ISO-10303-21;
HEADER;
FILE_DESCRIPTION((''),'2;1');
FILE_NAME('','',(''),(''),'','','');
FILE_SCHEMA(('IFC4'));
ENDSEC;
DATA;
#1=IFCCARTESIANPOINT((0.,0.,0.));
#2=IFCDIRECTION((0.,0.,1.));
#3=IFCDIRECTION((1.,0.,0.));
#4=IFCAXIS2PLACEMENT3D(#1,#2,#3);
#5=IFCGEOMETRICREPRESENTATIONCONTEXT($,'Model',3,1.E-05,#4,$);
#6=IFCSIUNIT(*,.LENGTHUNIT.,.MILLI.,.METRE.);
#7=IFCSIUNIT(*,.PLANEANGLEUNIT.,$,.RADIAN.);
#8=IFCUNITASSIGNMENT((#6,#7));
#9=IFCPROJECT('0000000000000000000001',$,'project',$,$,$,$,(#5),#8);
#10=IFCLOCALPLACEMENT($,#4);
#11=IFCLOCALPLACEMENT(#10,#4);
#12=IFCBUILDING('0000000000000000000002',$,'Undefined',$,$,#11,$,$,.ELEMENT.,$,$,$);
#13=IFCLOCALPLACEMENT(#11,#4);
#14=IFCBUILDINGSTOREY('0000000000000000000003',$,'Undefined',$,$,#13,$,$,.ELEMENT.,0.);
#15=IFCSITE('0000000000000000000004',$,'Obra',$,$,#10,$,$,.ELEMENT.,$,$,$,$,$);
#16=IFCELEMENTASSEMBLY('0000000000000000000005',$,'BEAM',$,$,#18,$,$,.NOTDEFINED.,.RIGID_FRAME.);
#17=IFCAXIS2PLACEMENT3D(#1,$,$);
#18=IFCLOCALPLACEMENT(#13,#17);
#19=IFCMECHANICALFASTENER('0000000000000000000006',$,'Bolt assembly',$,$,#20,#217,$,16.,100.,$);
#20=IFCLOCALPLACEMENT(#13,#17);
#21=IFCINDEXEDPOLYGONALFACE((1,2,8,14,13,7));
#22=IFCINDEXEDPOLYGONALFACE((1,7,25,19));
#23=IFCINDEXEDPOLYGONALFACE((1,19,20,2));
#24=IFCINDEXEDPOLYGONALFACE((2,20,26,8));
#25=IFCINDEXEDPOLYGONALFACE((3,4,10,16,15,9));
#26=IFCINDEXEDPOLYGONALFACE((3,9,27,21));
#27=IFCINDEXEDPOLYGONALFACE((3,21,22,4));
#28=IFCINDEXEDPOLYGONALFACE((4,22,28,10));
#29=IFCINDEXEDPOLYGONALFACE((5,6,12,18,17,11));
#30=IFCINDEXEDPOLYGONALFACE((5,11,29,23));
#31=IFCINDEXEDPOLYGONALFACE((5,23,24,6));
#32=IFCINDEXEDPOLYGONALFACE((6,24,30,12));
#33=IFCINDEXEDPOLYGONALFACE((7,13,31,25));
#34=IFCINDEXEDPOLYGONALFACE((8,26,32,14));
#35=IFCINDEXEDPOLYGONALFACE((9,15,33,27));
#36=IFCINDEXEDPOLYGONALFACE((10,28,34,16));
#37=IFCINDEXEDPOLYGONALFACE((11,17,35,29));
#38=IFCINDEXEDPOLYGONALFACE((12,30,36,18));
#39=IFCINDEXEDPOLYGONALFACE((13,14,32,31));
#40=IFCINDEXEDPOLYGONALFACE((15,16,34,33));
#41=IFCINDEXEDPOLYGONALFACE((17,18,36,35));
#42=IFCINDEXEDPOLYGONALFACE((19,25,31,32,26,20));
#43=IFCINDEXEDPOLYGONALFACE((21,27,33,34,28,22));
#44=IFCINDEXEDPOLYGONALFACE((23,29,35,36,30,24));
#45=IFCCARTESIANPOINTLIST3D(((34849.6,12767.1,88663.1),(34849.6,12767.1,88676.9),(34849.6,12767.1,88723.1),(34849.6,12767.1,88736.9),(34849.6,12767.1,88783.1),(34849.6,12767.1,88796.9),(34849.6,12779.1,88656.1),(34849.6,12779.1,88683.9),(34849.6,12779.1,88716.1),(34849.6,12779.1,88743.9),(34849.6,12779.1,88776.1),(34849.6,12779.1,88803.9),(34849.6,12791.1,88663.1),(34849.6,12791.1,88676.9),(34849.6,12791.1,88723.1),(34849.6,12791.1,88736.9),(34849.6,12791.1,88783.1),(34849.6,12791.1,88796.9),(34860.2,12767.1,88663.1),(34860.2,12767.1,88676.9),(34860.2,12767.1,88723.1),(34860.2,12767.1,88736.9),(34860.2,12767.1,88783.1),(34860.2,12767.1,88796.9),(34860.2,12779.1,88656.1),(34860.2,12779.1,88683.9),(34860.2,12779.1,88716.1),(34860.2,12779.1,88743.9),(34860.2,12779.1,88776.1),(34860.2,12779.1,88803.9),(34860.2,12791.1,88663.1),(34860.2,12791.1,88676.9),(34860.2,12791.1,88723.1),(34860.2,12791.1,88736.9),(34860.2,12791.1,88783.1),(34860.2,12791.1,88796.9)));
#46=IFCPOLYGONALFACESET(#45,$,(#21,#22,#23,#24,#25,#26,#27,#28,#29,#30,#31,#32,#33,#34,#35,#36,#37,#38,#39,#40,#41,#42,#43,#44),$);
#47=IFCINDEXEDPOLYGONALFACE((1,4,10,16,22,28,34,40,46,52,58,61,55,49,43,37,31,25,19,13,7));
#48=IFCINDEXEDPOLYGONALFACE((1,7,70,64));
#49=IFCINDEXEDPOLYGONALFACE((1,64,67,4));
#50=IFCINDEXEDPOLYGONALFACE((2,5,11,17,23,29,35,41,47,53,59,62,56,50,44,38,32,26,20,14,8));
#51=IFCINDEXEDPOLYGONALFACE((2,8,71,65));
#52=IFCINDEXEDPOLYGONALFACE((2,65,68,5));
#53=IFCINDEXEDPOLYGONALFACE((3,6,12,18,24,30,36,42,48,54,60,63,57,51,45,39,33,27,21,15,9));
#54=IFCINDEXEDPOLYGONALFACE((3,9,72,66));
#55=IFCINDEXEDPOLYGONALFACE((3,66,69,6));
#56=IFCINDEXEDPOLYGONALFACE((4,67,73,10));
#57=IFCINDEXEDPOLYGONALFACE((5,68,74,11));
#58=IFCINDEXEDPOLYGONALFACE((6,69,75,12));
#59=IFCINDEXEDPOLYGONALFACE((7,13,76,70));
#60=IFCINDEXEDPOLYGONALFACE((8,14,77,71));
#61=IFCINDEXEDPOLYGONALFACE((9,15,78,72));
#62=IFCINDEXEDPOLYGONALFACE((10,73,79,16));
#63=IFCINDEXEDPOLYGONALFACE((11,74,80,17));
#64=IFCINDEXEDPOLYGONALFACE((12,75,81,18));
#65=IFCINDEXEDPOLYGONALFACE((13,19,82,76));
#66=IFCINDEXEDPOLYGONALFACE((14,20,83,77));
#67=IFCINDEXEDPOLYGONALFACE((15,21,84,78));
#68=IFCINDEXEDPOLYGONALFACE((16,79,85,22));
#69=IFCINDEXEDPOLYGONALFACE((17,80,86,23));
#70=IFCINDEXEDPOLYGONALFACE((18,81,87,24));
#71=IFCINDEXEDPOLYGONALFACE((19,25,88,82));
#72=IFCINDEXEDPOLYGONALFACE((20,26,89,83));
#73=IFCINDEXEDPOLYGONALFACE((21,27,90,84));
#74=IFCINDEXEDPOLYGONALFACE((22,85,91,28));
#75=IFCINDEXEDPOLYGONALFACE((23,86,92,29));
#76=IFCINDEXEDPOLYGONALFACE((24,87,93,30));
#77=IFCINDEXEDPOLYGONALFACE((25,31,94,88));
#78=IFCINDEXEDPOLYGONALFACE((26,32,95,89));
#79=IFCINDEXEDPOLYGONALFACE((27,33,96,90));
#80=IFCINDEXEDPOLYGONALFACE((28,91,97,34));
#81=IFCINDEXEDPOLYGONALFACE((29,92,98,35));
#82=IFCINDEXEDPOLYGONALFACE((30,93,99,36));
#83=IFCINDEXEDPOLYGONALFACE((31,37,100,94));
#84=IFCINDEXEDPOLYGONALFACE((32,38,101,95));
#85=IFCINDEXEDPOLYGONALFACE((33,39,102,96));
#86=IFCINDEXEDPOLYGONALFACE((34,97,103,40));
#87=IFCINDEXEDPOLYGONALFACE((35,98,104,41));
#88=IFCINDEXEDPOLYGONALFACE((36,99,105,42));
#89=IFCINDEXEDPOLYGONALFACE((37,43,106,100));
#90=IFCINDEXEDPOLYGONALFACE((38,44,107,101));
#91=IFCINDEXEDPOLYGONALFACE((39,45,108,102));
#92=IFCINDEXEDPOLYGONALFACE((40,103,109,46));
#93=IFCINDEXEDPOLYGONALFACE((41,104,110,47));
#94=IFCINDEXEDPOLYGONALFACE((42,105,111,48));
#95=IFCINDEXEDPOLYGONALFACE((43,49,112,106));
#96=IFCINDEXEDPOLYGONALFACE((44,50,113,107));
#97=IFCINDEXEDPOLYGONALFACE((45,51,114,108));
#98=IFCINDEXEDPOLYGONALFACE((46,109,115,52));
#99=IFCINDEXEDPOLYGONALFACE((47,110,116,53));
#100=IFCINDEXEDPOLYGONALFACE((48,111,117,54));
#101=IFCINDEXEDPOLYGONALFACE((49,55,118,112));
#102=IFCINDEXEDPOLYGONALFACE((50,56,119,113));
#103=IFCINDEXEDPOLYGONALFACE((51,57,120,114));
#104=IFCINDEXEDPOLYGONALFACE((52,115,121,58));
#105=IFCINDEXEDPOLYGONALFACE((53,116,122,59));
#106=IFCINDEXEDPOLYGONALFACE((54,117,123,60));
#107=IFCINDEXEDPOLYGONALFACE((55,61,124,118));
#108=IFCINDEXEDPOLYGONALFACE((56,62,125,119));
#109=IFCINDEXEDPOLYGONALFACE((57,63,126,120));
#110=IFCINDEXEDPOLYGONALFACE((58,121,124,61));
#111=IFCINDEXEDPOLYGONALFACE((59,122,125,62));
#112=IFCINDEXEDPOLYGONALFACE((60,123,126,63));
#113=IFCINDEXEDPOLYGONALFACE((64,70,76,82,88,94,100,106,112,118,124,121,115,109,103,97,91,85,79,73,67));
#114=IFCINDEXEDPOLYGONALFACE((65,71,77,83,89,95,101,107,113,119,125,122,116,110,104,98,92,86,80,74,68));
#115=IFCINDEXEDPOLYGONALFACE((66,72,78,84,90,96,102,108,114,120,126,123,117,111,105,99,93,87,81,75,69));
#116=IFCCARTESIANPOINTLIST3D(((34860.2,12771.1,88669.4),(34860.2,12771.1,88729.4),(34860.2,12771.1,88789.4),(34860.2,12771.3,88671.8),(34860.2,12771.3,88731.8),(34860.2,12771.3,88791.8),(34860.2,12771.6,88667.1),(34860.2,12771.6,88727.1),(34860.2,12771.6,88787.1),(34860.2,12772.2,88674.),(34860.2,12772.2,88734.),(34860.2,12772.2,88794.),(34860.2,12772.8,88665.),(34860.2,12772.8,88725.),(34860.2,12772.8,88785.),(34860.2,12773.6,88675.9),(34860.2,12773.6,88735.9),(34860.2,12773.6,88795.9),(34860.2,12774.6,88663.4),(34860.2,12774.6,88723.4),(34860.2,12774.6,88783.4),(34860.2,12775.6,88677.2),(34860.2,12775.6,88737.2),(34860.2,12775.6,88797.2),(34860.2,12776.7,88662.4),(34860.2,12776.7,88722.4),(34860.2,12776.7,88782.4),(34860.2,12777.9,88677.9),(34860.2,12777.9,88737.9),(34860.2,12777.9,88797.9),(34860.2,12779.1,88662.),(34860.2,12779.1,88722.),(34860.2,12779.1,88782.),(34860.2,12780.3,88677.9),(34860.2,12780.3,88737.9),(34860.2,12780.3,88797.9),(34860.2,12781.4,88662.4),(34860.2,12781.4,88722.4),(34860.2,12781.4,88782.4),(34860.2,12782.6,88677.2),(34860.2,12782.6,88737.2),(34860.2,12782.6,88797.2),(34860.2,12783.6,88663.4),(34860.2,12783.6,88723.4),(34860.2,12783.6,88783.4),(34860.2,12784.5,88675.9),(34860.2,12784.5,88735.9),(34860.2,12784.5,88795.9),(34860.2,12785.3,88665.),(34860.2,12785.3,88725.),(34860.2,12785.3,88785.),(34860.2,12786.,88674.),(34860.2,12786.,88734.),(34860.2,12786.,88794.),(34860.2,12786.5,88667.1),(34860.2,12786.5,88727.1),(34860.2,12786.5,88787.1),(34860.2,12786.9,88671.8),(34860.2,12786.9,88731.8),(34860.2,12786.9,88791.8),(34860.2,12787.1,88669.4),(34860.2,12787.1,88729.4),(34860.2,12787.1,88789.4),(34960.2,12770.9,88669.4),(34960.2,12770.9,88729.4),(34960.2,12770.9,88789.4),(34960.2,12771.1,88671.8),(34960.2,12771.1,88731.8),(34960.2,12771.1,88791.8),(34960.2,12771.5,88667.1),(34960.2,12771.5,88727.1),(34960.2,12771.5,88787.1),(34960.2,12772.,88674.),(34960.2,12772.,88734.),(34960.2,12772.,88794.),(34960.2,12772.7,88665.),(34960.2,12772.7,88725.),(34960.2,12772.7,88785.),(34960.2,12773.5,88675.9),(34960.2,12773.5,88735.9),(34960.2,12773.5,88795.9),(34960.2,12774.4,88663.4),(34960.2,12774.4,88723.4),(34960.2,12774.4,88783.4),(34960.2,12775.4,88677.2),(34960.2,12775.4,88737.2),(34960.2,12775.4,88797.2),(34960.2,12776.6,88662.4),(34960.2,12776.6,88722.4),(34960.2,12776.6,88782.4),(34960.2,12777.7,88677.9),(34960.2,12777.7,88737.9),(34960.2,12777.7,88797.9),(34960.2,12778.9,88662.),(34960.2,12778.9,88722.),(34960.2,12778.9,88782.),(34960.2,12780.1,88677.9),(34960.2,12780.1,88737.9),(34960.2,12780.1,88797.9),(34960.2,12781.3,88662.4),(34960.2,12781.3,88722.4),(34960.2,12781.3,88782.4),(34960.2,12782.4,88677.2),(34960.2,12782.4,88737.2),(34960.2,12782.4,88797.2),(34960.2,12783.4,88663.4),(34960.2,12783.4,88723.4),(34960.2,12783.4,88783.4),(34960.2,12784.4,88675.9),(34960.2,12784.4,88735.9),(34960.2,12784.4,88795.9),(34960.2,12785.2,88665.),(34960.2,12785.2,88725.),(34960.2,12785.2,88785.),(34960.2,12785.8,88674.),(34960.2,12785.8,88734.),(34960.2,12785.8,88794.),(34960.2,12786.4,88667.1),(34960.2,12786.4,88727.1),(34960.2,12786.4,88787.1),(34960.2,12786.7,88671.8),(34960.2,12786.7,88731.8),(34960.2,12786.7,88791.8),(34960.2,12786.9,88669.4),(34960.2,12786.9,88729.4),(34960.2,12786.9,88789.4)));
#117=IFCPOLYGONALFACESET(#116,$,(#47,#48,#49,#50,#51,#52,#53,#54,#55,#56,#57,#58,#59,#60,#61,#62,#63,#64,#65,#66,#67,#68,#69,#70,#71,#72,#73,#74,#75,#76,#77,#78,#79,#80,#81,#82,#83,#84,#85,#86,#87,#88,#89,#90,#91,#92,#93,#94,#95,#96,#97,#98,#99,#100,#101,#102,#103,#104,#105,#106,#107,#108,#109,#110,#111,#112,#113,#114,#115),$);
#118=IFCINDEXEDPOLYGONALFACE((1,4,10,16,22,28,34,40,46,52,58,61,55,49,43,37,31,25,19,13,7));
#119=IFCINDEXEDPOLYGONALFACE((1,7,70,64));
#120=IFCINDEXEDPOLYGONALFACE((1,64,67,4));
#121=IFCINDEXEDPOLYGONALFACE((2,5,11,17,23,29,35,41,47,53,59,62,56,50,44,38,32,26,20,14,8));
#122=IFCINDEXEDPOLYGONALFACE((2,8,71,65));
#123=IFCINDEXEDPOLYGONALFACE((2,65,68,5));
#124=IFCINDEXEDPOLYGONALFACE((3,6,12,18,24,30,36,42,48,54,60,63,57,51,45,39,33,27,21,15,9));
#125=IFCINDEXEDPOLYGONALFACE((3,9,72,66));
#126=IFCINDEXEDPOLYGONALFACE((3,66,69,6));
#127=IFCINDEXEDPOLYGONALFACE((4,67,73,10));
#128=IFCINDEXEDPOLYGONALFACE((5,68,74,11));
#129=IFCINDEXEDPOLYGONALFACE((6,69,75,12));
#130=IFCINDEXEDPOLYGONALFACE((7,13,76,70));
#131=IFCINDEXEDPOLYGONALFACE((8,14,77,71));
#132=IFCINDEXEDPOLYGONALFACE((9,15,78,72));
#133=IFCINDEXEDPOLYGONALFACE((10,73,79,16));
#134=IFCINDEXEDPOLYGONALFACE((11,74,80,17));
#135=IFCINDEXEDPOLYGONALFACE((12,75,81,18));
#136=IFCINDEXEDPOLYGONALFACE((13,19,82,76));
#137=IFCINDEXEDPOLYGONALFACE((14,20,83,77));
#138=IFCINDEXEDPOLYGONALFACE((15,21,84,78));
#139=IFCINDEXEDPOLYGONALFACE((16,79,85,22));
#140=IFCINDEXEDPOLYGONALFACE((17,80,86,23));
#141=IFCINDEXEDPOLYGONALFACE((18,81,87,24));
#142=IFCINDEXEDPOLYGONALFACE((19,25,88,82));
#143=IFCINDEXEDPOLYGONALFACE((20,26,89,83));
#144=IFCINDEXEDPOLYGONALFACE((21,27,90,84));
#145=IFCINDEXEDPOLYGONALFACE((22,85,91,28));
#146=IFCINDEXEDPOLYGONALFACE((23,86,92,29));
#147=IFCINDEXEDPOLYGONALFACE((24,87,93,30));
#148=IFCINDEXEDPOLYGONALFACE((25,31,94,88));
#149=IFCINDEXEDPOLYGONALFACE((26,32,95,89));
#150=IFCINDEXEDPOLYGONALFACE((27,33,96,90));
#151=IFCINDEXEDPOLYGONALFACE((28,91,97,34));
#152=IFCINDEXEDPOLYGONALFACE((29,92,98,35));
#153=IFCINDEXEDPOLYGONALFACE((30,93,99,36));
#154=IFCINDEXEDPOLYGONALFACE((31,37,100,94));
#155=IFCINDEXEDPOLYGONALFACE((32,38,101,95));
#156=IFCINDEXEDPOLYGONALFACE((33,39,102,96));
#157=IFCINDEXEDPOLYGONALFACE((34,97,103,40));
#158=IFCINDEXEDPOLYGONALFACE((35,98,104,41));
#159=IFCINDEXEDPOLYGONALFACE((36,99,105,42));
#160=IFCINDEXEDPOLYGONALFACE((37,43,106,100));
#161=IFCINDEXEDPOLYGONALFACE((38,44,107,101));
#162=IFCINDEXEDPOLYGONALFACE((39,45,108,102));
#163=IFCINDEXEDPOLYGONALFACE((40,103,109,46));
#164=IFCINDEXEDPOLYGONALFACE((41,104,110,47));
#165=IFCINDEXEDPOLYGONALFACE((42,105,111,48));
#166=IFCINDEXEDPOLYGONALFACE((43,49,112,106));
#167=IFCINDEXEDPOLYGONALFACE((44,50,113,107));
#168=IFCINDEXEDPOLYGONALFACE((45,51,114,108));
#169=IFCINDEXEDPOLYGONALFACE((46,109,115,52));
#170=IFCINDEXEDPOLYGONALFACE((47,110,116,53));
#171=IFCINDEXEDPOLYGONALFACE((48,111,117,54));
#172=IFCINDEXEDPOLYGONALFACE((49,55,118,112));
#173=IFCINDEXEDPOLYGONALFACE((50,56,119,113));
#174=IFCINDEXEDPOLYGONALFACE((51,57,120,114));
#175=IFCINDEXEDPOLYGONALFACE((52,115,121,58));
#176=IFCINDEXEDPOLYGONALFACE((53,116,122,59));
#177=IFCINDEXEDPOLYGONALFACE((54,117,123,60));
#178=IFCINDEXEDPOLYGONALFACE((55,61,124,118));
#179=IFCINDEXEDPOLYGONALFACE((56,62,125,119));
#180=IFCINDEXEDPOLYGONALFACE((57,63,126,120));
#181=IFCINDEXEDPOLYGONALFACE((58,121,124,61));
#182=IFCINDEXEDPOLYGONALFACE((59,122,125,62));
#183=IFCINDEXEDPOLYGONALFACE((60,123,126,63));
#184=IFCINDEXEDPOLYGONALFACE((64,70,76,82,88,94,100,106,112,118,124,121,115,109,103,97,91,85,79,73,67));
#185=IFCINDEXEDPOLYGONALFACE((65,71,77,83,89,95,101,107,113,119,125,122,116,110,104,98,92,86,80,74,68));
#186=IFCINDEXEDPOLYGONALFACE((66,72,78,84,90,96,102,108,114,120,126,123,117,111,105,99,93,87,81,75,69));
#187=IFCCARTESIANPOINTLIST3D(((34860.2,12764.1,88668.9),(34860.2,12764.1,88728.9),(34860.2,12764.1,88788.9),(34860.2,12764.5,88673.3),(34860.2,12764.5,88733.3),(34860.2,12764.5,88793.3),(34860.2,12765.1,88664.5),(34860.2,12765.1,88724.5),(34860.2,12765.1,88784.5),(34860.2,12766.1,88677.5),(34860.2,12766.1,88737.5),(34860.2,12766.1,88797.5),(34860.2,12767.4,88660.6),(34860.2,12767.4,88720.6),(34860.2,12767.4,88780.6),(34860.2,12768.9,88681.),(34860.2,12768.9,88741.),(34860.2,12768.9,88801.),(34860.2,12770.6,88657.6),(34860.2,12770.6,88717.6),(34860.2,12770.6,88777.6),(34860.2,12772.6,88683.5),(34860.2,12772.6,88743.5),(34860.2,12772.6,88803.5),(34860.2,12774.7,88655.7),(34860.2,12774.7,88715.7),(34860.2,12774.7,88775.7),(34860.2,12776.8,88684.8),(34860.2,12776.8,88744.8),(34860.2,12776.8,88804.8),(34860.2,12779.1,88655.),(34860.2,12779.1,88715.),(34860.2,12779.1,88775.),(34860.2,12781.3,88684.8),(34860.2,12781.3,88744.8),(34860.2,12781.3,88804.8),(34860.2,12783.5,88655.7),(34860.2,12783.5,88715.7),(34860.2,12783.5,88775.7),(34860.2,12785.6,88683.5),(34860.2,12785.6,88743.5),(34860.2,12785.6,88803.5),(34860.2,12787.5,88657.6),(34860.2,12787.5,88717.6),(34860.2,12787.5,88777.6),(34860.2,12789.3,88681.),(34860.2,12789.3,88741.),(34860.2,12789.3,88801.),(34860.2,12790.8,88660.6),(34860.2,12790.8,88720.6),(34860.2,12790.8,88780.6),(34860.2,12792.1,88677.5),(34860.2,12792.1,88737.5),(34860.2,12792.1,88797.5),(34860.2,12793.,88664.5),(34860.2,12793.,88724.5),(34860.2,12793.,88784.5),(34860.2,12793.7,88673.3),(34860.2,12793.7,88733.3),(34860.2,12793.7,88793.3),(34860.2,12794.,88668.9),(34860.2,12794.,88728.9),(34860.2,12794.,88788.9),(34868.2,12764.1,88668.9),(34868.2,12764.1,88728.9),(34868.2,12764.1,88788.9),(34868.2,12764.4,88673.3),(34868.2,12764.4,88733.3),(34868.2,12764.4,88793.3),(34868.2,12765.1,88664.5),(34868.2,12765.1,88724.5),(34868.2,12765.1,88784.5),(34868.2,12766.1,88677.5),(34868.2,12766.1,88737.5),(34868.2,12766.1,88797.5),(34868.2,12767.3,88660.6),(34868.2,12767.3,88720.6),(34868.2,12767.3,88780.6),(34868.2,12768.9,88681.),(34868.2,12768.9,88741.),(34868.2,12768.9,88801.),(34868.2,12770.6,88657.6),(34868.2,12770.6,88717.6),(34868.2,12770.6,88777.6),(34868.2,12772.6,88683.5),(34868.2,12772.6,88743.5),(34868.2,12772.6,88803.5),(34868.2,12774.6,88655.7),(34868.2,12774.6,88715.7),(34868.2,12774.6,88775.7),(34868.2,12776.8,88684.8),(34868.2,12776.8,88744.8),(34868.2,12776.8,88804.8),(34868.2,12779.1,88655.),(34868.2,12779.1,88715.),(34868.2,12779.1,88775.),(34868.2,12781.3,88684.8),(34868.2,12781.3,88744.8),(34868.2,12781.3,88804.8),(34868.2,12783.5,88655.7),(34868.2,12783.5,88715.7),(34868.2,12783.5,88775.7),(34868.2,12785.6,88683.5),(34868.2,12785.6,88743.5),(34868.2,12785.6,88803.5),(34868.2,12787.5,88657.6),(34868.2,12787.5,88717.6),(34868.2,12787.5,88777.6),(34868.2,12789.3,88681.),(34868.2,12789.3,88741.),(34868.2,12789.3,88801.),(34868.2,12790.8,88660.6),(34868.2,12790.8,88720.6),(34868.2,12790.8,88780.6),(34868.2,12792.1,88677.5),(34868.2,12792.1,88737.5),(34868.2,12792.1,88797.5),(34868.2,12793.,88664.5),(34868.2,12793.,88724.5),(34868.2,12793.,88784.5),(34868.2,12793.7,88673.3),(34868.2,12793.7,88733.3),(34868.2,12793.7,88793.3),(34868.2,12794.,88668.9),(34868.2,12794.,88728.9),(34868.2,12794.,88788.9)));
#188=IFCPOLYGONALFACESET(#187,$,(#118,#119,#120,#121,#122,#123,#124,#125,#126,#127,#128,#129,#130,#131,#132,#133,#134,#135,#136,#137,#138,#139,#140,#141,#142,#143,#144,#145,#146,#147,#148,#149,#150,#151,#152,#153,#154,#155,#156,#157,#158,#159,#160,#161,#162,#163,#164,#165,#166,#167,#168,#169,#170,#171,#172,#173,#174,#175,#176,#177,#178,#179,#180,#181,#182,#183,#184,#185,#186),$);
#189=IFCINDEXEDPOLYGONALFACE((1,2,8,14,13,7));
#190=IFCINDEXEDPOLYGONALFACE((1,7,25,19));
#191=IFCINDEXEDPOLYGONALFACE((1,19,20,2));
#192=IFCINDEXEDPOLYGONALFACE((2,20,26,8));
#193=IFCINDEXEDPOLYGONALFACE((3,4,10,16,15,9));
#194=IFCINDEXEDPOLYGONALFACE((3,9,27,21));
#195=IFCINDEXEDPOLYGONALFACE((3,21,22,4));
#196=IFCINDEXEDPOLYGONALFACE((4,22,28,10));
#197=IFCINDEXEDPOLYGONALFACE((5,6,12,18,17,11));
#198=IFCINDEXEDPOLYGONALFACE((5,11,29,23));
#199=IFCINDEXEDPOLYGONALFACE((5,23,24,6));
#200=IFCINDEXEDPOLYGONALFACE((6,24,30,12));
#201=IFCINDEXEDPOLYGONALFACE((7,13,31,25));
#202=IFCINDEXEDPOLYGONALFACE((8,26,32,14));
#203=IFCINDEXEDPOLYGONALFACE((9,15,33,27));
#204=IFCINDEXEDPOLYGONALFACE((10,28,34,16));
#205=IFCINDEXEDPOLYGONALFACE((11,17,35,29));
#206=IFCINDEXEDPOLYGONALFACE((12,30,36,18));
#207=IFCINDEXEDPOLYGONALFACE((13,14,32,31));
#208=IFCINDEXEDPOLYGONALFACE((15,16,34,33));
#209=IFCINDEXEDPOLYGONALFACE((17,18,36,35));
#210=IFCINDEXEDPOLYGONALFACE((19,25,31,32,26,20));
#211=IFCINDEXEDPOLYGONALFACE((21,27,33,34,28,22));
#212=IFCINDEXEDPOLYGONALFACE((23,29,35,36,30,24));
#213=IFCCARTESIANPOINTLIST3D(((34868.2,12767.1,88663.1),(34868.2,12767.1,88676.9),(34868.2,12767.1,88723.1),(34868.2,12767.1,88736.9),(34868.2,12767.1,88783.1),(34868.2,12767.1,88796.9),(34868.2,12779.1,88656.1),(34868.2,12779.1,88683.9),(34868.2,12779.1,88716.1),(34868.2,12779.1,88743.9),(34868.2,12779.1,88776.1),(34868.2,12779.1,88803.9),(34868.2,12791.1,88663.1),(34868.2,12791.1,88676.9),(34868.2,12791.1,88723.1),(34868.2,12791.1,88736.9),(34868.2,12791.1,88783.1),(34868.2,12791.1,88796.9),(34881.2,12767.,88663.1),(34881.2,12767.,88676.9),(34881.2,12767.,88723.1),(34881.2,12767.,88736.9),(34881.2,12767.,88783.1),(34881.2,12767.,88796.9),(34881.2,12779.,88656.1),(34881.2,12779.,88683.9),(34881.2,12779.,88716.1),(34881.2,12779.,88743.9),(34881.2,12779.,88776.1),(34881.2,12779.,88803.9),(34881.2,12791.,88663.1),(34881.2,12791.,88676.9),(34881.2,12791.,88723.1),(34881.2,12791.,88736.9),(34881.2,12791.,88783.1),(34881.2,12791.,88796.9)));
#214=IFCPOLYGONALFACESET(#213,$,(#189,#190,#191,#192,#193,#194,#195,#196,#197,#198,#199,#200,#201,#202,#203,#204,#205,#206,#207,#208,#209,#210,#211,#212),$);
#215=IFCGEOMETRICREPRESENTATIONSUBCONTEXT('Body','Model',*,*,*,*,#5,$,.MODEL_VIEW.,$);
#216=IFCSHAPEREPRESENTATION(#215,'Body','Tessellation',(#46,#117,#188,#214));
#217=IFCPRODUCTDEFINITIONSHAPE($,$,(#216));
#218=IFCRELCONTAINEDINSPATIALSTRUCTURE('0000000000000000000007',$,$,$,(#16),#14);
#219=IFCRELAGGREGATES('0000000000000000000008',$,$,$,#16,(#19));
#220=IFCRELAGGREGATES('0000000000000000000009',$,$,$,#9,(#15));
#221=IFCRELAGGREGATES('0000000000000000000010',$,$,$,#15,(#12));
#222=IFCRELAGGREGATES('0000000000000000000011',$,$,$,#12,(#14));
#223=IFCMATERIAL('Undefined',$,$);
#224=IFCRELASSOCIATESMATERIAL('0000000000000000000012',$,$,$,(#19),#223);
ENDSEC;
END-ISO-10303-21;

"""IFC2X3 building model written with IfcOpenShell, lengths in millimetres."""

from ifc_helpers import new_model, si_unit, frame, origin_with_axes, origin_2d_with_axis, place, context, subcontext, project, spatial, polyline, circle, outline, extrude, source, transform, mapped, material, element, aggregate, save


model = new_model("IFC2X3")

# Units and contexts
model_context = context("Model", 3, precision=1e-05, world=origin_with_axes())
body_context = subcontext(model_context, "Body", "Model", "MODEL_VIEW")
ifc_project = project(units=[si_unit("LENGTHUNIT", "METRE", prefix="MILLI"), si_unit("PLANEANGLEUNIT", "RADIAN")], contexts=[model_context])

# Site, building, storey
site_placement = place(None, origin_with_axes())
site = spatial("IfcSite", under=ifc_project, at=site_placement, Name="Obra", CompositionType="ELEMENT")
building_placement = place(site_placement, origin_with_axes())
building = spatial("IfcBuilding", under=site, at=building_placement, Name="Undefined", CompositionType="ELEMENT")
storey_placement = place(building_placement, origin_with_axes())
storey = spatial("IfcBuildingStorey", under=building, at=storey_placement, Name="Undefined", CompositionType="ELEMENT", Elevation=0.0)

# Shared definitions
ifc_material_1 = material(Name="Undefined")

# Element assembly, mechanical fastener
assembly_1_placement = place(storey_placement, origin_with_axes())
assembly_1 = element("IfcElementAssembly", 1, at=assembly_1_placement, inside=storey, Name="BEAM", AssemblyPlace="NOTDEFINED", PredefinedType="RIGID_FRAME")
shared_shape_1 = source(origin_with_axes(), body_context, "Body", "SweptSolid", [
    extrude(outline(polyline([(13.9, 0.0), (6.9, 12.0), (-6.9, 12.0), (-13.9, 0.0), (-6.9, -12.0), (6.9, -12.0), (13.9, 0.0)])), frame((0.0, -10.6, 0.0), z_axis=(0.0, 1.0, 0.0), x_axis=(1.0, 0.0, 0.0)), (0.0, 0.0, 1.0), 10.6),
    extrude(circle(Radius=8.0, at=origin_2d_with_axis()), frame((0.0, 0.0, 0.0), z_axis=(0.0, 1.0, 0.0), x_axis=(1.0, 0.0, 0.0)), (0.0, 0.0, 1.0), 100.0),
    extrude(circle(Radius=15.0, at=origin_2d_with_axis()), frame((0.0, 0.0, 0.0), z_axis=(0.0, 1.0, 0.0), x_axis=(1.0, 0.0, 0.0)), (0.0, 0.0, 1.0), 8.0),
    extrude(outline(polyline([(13.9, 0.0), (6.9, 12.0), (-6.9, 12.0), (-13.9, 0.0), (-6.9, -12.0), (6.9, -12.0), (13.9, 0.0)])), frame((0.0, 8.0, 0.0), z_axis=(0.0, 1.0, 0.0), x_axis=(1.0, 0.0, 0.0)), (0.0, 0.0, 1.0), 13.0),
])
mechanical_fastener_1_placement = place(assembly_1_placement, frame((34860.3, 12829.1, 88850.0), z_axis=(-0.001625, -0.999999, 0.0), x_axis=(0.0, 0.0, -1.0)))
mechanical_fastener_1 = element("IfcMechanicalFastener", 2, at=mechanical_fastener_1_placement, material=ifc_material_1, Name="Bolt assembly", NominalDiameter=16.0, NominalLength=100.0, context=body_context, shape_type="MappedRepresentation", body=[
    mapped(shared_shape_1, transform((60.0, 0.0, 50.0))),
    mapped(shared_shape_1, transform((120.0, 0.0, 50.0))),
    mapped(shared_shape_1, transform((180.0, 0.0, 50.0))),
])
aggregate(assembly_1, [mechanical_fastener_1])

save(model, "model.ifc")
